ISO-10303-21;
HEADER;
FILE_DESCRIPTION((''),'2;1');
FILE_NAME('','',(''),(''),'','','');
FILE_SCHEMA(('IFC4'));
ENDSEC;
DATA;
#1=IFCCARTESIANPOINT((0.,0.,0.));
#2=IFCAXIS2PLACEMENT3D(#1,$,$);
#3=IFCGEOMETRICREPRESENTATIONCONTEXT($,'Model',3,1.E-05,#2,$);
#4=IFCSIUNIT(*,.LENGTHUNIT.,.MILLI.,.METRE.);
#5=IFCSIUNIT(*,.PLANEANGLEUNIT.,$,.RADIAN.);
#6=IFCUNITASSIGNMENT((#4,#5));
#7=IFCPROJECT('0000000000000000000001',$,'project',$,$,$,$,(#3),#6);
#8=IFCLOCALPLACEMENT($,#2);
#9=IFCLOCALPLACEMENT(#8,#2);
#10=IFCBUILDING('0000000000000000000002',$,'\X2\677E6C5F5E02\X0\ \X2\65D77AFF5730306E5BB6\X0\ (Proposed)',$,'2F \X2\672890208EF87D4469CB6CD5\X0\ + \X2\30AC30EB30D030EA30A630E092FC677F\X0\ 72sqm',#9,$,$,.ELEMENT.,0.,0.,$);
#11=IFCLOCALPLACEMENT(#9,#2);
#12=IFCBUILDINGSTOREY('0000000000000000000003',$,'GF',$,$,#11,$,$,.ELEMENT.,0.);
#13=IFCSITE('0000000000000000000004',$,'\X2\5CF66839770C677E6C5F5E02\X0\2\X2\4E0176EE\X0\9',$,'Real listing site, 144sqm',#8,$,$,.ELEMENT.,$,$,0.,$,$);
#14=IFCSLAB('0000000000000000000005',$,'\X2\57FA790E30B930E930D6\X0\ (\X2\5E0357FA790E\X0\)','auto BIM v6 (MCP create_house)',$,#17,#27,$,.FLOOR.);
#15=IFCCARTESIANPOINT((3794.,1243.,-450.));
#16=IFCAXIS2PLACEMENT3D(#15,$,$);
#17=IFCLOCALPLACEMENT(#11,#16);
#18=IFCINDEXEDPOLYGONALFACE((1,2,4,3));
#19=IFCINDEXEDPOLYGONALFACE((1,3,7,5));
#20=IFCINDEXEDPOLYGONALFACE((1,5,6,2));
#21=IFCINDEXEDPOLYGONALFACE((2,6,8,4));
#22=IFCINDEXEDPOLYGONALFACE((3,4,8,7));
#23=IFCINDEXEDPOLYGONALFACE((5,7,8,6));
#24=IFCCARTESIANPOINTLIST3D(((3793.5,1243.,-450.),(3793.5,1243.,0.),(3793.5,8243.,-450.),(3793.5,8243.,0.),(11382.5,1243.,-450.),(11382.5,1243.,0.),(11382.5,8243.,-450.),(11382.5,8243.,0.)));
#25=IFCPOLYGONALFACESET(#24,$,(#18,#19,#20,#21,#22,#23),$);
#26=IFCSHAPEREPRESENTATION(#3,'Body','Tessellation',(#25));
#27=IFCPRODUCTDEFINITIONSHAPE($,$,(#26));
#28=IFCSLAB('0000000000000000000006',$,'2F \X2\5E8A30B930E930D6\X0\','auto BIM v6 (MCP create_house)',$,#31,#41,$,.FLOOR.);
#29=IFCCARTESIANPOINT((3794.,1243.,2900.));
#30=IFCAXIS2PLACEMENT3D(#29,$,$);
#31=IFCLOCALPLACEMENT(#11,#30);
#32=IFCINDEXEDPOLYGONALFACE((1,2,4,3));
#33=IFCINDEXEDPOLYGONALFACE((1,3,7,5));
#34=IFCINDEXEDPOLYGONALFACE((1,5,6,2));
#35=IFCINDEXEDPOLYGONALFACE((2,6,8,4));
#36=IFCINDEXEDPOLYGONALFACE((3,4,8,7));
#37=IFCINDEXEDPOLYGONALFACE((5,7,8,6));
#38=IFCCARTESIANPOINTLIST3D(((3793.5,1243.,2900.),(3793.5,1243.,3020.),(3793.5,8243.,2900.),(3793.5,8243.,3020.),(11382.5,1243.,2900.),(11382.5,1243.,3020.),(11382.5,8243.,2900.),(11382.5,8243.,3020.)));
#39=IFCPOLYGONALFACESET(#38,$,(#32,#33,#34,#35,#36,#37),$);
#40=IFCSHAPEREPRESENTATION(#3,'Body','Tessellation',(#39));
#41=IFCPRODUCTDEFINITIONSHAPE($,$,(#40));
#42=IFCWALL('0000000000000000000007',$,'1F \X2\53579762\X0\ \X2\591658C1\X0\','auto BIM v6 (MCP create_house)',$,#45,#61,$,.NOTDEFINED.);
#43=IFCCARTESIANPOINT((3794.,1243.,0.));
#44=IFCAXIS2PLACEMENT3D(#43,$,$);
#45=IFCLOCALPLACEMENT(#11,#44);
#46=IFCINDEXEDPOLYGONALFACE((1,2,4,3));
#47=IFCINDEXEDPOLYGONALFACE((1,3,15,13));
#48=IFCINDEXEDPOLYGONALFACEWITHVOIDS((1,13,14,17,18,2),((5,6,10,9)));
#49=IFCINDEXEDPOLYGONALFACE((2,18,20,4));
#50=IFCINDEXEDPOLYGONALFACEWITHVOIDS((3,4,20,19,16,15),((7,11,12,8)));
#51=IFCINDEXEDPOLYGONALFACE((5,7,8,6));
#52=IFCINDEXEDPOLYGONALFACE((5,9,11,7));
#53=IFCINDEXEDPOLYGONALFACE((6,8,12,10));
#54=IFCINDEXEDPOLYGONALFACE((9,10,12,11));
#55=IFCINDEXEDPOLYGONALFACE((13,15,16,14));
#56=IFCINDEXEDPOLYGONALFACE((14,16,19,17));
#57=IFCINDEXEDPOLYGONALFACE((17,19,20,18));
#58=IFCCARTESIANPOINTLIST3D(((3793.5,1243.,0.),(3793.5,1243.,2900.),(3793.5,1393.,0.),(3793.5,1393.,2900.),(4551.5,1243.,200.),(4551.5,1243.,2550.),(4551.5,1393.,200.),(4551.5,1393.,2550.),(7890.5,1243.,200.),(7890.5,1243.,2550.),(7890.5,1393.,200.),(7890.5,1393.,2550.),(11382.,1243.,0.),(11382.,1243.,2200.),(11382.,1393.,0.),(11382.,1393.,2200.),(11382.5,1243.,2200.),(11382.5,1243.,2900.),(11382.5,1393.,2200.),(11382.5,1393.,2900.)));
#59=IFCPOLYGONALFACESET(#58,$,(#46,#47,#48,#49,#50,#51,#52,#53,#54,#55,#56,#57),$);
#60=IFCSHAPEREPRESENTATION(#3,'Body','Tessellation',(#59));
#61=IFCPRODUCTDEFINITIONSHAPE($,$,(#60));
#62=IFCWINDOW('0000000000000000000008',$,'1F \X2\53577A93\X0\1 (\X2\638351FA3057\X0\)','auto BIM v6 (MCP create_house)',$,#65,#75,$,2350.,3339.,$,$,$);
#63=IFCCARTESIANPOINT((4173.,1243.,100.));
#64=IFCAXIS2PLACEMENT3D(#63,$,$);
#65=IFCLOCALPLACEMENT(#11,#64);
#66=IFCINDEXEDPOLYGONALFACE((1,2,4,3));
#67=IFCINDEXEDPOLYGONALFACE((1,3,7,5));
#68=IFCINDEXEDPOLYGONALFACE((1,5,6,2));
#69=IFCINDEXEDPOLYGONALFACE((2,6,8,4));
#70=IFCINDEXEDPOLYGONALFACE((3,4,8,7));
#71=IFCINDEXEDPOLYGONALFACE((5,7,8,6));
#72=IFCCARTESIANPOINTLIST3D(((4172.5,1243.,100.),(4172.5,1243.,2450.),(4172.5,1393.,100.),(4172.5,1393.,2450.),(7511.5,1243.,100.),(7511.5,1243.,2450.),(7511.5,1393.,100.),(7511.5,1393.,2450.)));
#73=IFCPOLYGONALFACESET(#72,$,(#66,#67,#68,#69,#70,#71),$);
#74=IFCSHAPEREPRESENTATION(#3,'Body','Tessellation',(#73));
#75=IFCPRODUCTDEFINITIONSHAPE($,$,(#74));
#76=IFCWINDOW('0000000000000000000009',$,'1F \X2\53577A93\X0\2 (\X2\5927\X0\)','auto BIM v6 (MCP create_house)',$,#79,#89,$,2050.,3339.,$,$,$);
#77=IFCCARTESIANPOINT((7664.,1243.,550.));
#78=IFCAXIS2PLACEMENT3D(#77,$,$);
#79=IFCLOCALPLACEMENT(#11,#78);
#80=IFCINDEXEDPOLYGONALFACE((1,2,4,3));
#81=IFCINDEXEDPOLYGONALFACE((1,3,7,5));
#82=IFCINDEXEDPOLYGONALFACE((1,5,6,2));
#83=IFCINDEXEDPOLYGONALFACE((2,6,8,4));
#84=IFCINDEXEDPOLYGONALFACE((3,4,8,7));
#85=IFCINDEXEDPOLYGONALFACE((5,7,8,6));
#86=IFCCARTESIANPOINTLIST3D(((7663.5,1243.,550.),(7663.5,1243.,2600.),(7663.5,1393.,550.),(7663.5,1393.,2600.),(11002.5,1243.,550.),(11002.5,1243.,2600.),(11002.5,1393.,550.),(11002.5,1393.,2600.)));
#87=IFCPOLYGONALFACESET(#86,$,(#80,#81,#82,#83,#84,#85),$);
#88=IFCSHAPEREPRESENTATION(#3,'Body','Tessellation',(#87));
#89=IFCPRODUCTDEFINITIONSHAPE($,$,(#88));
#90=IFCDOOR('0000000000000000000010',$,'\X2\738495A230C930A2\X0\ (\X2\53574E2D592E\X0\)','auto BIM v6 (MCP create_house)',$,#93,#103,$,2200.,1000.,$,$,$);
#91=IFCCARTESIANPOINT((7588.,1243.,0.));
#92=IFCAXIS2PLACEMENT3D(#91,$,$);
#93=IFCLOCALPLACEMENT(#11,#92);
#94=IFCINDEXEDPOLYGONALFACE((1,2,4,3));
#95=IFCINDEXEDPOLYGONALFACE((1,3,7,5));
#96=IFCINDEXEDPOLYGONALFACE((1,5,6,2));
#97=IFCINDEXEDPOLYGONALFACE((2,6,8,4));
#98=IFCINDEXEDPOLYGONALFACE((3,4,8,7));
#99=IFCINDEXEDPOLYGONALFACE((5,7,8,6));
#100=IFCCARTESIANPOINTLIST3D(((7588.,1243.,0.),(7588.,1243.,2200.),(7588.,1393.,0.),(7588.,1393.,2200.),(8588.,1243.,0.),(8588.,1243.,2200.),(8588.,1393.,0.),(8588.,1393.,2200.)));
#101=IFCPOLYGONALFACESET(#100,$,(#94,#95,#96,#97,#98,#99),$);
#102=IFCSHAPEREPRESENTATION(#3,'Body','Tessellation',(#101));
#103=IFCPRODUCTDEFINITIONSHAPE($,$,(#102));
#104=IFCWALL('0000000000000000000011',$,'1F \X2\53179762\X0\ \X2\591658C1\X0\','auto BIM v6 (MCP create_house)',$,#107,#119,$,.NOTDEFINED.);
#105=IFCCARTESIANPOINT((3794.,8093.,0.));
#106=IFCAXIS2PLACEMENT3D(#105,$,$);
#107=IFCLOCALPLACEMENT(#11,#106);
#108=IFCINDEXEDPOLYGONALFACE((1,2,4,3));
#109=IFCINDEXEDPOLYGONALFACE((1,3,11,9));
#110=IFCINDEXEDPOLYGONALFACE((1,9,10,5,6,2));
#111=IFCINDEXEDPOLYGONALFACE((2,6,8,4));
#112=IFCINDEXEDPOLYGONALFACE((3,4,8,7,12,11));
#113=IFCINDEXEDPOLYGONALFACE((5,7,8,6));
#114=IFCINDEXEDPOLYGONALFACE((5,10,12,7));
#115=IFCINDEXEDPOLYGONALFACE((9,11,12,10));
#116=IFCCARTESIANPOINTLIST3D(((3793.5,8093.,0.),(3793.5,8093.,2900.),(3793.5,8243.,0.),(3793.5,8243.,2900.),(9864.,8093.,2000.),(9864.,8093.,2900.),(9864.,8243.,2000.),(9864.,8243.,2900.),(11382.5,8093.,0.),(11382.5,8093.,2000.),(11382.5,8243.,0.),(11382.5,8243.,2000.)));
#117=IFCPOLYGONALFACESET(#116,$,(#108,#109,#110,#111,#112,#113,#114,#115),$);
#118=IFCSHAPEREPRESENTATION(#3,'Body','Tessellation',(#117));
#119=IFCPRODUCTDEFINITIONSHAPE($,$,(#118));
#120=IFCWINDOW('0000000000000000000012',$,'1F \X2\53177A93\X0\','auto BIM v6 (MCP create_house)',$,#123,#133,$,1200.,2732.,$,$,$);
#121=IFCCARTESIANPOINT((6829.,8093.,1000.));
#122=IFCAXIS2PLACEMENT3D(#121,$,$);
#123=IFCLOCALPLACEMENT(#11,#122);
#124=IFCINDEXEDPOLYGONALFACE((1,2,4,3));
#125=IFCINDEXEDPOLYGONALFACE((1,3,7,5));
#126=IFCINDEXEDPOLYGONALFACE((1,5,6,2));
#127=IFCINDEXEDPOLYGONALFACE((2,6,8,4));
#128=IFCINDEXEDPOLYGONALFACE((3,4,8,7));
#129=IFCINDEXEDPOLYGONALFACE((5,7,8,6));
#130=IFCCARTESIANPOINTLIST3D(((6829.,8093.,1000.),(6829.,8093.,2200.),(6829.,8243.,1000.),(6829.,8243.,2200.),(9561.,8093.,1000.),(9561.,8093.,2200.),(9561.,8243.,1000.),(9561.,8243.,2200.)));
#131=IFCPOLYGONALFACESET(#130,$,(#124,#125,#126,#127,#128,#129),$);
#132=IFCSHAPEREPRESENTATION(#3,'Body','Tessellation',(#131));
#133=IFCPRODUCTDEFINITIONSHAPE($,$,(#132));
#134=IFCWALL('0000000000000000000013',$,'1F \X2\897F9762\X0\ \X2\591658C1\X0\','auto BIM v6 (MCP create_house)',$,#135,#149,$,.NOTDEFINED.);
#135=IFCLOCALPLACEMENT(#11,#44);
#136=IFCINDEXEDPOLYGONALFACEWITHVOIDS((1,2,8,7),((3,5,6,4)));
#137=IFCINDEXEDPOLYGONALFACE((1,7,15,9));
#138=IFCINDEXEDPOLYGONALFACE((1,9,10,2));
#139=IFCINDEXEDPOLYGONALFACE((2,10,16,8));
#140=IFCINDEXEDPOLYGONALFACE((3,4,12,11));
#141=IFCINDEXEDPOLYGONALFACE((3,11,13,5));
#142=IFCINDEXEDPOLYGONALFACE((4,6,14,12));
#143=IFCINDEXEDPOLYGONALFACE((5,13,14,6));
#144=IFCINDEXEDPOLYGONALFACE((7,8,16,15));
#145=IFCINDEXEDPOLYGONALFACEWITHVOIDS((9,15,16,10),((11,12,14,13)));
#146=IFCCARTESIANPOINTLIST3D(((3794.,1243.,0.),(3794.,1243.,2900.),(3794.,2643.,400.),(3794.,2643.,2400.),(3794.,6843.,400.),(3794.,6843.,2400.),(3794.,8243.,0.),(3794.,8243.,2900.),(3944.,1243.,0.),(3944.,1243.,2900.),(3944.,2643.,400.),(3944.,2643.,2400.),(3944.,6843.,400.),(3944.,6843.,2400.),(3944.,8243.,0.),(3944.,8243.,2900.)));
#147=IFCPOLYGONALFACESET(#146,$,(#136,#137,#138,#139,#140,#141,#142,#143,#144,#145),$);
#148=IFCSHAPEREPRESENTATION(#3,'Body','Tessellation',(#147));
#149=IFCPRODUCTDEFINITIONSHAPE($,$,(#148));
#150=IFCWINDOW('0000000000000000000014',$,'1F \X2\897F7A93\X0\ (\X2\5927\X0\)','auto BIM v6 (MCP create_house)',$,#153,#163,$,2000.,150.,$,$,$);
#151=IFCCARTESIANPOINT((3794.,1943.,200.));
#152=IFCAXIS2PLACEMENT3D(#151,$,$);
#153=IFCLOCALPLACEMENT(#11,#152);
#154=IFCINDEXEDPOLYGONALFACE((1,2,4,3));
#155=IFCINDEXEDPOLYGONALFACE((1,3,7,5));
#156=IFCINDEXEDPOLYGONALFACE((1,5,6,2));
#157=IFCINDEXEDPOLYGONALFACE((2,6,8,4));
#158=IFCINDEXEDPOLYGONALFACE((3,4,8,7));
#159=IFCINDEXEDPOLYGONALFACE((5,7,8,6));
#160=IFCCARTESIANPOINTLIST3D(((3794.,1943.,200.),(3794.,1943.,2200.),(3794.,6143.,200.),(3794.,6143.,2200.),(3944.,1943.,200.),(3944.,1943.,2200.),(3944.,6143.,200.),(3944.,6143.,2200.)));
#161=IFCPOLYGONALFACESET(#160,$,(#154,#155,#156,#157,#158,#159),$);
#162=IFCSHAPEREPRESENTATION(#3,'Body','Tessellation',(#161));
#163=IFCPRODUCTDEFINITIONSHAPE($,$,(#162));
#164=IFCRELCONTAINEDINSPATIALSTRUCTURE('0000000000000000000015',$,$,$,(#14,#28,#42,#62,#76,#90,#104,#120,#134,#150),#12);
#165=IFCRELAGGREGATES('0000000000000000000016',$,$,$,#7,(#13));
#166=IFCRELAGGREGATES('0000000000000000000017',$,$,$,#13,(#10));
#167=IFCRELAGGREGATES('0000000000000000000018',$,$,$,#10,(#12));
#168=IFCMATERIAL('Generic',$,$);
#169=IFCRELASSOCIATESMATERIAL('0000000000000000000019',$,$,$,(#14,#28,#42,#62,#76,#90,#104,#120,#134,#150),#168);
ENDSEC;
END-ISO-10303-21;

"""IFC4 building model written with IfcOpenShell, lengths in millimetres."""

from ifc_helpers import new_model, si_unit, frame, frame_2d, origin, place, context, project, spatial, rectangle, extrude, material, element, fill, save


model = new_model("IFC4")

# Units and contexts
model_context = context("Model", 3, precision=1e-05, world=origin())
ifc_project = project(units=[si_unit("LENGTHUNIT", "METRE", prefix="MILLI"), si_unit("PLANEANGLEUNIT", "RADIAN")], contexts=[model_context])

# Site, building, storey
site_placement = place(None, origin())
site = spatial("IfcSite", under=ifc_project, at=site_placement, Name="島根県松江市2丁目9", ObjectType="Real listing site, 144sqm", CompositionType="ELEMENT", RefElevation=0.0)
building_placement = place(site_placement, origin())
building = spatial("IfcBuilding", under=site, at=building_placement, Name="松江市 旗竿地の家 (Proposed)", ObjectType="2F 木造軸組構法 + ガルバリウム鋼板 72sqm", CompositionType="ELEMENT", ElevationOfRefHeight=0.0, ElevationOfTerrain=0.0)
storey_placement = place(building_placement, origin())
storey = spatial("IfcBuildingStorey", under=building, at=storey_placement, Name="GF", CompositionType="ELEMENT", Elevation=0.0)

# Slabs
ifc_material = material(Name="Generic")
slab_1_placement = place(storey_placement, frame((3794.0, 1243.0, -450.0)))
element("IfcSlab", 1, at=slab_1_placement, inside=storey, material=ifc_material, Name="基礎スラブ (布基礎)", Description="auto BIM v6 (MCP create_house)", PredefinedType="FLOOR", context=model_context, shape_type="SweptSolid", body=[
    extrude(rectangle(XDim=7589.0, YDim=7000.0, at=frame_2d((3794.0, 3500.0))), frame((3794.0, 1243.0, -450.0)), (0.0, 0.0, 1.0), 450.0),
])
slab_2_placement = place(storey_placement, frame((3794.0, 1243.0, 2900.0)))
element("IfcSlab", 2, at=slab_2_placement, inside=storey, material=ifc_material, Name="2F 床スラブ", Description="auto BIM v6 (MCP create_house)", PredefinedType="FLOOR", context=model_context, shape_type="SweptSolid", body=[
    extrude(rectangle(XDim=7589.0, YDim=7000.0, at=frame_2d((3794.0, 3500.0))), frame((3794.0, 1243.0, 2900.0)), (0.0, 0.0, 1.0), 120.0),
])

# Wall, openings, windows, door
wall_1_placement = place(storey_placement, frame((3794.0, 1243.0, 0.0)))
wall_1 = element("IfcWall", 3, at=wall_1_placement, inside=storey, material=ifc_material, Name="1F 南面 外壁", Description="auto BIM v6 (MCP create_house)", PredefinedType="NOTDEFINED", context=model_context, shape_type="SweptSolid", body=[
    extrude(rectangle(XDim=7589.0, YDim=150.0, at=frame_2d((3794.0, 75.0))), frame((3794.0, 1243.0, 0.0)), (0.0, 0.0, 1.0), 2900.0),
])
opening_1_placement = place(storey_placement, frame((4173.0, 1243.0, 100.0)))
opening_1 = element("IfcOpeningElement", 4, at=opening_1_placement, cuts=wall_1, PredefinedType="NOTDEFINED", context=model_context, shape_type="SweptSolid", body=[
    extrude(rectangle(XDim=3339.0, YDim=150.0, at=frame_2d((1669.0, 75.0))), frame((4173.0, 1243.0, 100.0)), (0.0, 0.0, 1.0), 2350.0),
])
opening_2_placement = place(storey_placement, frame((7664.0, 1243.0, 550.0)))
opening_2 = element("IfcOpeningElement", 5, at=opening_2_placement, cuts=wall_1, PredefinedType="NOTDEFINED", context=model_context, shape_type="SweptSolid", body=[
    extrude(rectangle(XDim=3339.0, YDim=150.0, at=frame_2d((1669.0, 75.0))), frame((7664.0, 1243.0, 550.0)), (0.0, 0.0, 1.0), 2050.0),
])
opening_3_placement = place(storey_placement, frame((7588.0, 1243.0, 0.0)))
opening_3 = element("IfcOpeningElement", 6, at=opening_3_placement, cuts=wall_1, PredefinedType="NOTDEFINED", context=model_context, shape_type="SweptSolid", body=[
    extrude(rectangle(XDim=1000.0, YDim=150.0, at=frame_2d((500.0, 75.0))), frame((7588.0, 1243.0, 0.0)), (0.0, 0.0, 1.0), 2200.0),
])
window_1_placement = place(storey_placement, frame((4173.0, 1243.0, 100.0)))
window_1 = element("IfcWindow", 7, at=window_1_placement, inside=storey, material=ifc_material, Name="1F 南窓1 (掃出し)", Description="auto BIM v6 (MCP create_house)", OverallHeight=2350.0, OverallWidth=3339.0, context=model_context, shape_type="SweptSolid", body=[
    extrude(rectangle(XDim=3339.0, YDim=150.0, at=frame_2d((1669.0, 75.0))), frame((4173.0, 1243.0, 100.0)), (0.0, 0.0, 1.0), 2350.0),
])
fill(opening_1, window_1)
window_2_placement = place(storey_placement, frame((7664.0, 1243.0, 550.0)))
window_2 = element("IfcWindow", 8, at=window_2_placement, inside=storey, material=ifc_material, Name="1F 南窓2 (大)", Description="auto BIM v6 (MCP create_house)", OverallHeight=2050.0, OverallWidth=3339.0, context=model_context, shape_type="SweptSolid", body=[
    extrude(rectangle(XDim=3339.0, YDim=150.0, at=frame_2d((1669.0, 75.0))), frame((7664.0, 1243.0, 550.0)), (0.0, 0.0, 1.0), 2050.0),
])
fill(opening_2, window_2)
door_placement = place(storey_placement, frame((7588.0, 1243.0, 0.0)))
door = element("IfcDoor", 9, at=door_placement, inside=storey, material=ifc_material, Name="玄関ドア (南中央)", Description="auto BIM v6 (MCP create_house)", OverallHeight=2200.0, OverallWidth=1000.0, context=model_context, shape_type="SweptSolid", body=[
    extrude(rectangle(XDim=1000.0, YDim=150.0, at=frame_2d((500.0, 75.0))), frame((7588.0, 1243.0, 0.0)), (0.0, 0.0, 1.0), 2200.0),
])
fill(opening_3, door)

# Walls, openings, windows
wall_2_placement = place(storey_placement, frame((3794.0, 8093.0, 0.0)))
wall_2 = element("IfcWall", 10, at=wall_2_placement, inside=storey, material=ifc_material, Name="1F 北面 外壁", Description="auto BIM v6 (MCP create_house)", PredefinedType="NOTDEFINED", context=model_context, shape_type="SweptSolid", body=[
    extrude(rectangle(XDim=7589.0, YDim=150.0, at=frame_2d((3794.0, 75.0))), frame((3794.0, 8093.0, 0.0)), (0.0, 0.0, 1.0), 2900.0),
])
opening_4_placement = place(storey_placement, frame((6829.0, 8093.0, 1000.0)))
opening_4 = element("IfcOpeningElement", 11, at=opening_4_placement, cuts=wall_2, PredefinedType="NOTDEFINED", context=model_context, shape_type="SweptSolid", body=[
    extrude(rectangle(XDim=2732.0, YDim=150.0, at=frame_2d((1366.0, 75.0))), frame((6829.0, 8093.0, 1000.0)), (0.0, 0.0, 1.0), 1200.0),
])
window_3_placement = place(storey_placement, frame((6829.0, 8093.0, 1000.0)))
window_3 = element("IfcWindow", 12, at=window_3_placement, inside=storey, material=ifc_material, Name="1F 北窓", Description="auto BIM v6 (MCP create_house)", OverallHeight=1200.0, OverallWidth=2732.0, context=model_context, shape_type="SweptSolid", body=[
    extrude(rectangle(XDim=2732.0, YDim=150.0, at=frame_2d((1366.0, 75.0))), frame((6829.0, 8093.0, 1000.0)), (0.0, 0.0, 1.0), 1200.0),
])
fill(opening_4, window_3)
wall_3_placement = place(storey_placement, frame((3794.0, 1243.0, 0.0)))
wall_3 = element("IfcWall", 13, at=wall_3_placement, inside=storey, material=ifc_material, Name="1F 西面 外壁", Description="auto BIM v6 (MCP create_house)", PredefinedType="NOTDEFINED", context=model_context, shape_type="SweptSolid", body=[
    extrude(rectangle(XDim=150.0, YDim=7000.0, at=frame_2d((75.0, 3500.0))), frame((3794.0, 1243.0, 0.0)), (0.0, 0.0, 1.0), 2900.0),
])
opening_5_placement = place(storey_placement, frame((3794.0, 1943.0, 200.0)))
opening_5 = element("IfcOpeningElement", 14, at=opening_5_placement, cuts=wall_3, PredefinedType="NOTDEFINED", context=model_context, shape_type="SweptSolid", body=[
    extrude(rectangle(XDim=150.0, YDim=4200.0, at=frame_2d((75.0, 2100.0))), frame((3794.0, 1943.0, 200.0)), (0.0, 0.0, 1.0), 2000.0),
])
window_4_placement = place(storey_placement, frame((3794.0, 1943.0, 200.0)))
window_4 = element("IfcWindow", 15, at=window_4_placement, inside=storey, material=ifc_material, Name="1F 西窓 (大)", Description="auto BIM v6 (MCP create_house)", OverallHeight=2000.0, OverallWidth=150.0, context=model_context, shape_type="SweptSolid", body=[
    extrude(rectangle(XDim=150.0, YDim=4200.0, at=frame_2d((75.0, 2100.0))), frame((3794.0, 1943.0, 200.0)), (0.0, 0.0, 1.0), 2000.0),
])
fill(opening_5, window_4)

save(model, "model.ifc")
